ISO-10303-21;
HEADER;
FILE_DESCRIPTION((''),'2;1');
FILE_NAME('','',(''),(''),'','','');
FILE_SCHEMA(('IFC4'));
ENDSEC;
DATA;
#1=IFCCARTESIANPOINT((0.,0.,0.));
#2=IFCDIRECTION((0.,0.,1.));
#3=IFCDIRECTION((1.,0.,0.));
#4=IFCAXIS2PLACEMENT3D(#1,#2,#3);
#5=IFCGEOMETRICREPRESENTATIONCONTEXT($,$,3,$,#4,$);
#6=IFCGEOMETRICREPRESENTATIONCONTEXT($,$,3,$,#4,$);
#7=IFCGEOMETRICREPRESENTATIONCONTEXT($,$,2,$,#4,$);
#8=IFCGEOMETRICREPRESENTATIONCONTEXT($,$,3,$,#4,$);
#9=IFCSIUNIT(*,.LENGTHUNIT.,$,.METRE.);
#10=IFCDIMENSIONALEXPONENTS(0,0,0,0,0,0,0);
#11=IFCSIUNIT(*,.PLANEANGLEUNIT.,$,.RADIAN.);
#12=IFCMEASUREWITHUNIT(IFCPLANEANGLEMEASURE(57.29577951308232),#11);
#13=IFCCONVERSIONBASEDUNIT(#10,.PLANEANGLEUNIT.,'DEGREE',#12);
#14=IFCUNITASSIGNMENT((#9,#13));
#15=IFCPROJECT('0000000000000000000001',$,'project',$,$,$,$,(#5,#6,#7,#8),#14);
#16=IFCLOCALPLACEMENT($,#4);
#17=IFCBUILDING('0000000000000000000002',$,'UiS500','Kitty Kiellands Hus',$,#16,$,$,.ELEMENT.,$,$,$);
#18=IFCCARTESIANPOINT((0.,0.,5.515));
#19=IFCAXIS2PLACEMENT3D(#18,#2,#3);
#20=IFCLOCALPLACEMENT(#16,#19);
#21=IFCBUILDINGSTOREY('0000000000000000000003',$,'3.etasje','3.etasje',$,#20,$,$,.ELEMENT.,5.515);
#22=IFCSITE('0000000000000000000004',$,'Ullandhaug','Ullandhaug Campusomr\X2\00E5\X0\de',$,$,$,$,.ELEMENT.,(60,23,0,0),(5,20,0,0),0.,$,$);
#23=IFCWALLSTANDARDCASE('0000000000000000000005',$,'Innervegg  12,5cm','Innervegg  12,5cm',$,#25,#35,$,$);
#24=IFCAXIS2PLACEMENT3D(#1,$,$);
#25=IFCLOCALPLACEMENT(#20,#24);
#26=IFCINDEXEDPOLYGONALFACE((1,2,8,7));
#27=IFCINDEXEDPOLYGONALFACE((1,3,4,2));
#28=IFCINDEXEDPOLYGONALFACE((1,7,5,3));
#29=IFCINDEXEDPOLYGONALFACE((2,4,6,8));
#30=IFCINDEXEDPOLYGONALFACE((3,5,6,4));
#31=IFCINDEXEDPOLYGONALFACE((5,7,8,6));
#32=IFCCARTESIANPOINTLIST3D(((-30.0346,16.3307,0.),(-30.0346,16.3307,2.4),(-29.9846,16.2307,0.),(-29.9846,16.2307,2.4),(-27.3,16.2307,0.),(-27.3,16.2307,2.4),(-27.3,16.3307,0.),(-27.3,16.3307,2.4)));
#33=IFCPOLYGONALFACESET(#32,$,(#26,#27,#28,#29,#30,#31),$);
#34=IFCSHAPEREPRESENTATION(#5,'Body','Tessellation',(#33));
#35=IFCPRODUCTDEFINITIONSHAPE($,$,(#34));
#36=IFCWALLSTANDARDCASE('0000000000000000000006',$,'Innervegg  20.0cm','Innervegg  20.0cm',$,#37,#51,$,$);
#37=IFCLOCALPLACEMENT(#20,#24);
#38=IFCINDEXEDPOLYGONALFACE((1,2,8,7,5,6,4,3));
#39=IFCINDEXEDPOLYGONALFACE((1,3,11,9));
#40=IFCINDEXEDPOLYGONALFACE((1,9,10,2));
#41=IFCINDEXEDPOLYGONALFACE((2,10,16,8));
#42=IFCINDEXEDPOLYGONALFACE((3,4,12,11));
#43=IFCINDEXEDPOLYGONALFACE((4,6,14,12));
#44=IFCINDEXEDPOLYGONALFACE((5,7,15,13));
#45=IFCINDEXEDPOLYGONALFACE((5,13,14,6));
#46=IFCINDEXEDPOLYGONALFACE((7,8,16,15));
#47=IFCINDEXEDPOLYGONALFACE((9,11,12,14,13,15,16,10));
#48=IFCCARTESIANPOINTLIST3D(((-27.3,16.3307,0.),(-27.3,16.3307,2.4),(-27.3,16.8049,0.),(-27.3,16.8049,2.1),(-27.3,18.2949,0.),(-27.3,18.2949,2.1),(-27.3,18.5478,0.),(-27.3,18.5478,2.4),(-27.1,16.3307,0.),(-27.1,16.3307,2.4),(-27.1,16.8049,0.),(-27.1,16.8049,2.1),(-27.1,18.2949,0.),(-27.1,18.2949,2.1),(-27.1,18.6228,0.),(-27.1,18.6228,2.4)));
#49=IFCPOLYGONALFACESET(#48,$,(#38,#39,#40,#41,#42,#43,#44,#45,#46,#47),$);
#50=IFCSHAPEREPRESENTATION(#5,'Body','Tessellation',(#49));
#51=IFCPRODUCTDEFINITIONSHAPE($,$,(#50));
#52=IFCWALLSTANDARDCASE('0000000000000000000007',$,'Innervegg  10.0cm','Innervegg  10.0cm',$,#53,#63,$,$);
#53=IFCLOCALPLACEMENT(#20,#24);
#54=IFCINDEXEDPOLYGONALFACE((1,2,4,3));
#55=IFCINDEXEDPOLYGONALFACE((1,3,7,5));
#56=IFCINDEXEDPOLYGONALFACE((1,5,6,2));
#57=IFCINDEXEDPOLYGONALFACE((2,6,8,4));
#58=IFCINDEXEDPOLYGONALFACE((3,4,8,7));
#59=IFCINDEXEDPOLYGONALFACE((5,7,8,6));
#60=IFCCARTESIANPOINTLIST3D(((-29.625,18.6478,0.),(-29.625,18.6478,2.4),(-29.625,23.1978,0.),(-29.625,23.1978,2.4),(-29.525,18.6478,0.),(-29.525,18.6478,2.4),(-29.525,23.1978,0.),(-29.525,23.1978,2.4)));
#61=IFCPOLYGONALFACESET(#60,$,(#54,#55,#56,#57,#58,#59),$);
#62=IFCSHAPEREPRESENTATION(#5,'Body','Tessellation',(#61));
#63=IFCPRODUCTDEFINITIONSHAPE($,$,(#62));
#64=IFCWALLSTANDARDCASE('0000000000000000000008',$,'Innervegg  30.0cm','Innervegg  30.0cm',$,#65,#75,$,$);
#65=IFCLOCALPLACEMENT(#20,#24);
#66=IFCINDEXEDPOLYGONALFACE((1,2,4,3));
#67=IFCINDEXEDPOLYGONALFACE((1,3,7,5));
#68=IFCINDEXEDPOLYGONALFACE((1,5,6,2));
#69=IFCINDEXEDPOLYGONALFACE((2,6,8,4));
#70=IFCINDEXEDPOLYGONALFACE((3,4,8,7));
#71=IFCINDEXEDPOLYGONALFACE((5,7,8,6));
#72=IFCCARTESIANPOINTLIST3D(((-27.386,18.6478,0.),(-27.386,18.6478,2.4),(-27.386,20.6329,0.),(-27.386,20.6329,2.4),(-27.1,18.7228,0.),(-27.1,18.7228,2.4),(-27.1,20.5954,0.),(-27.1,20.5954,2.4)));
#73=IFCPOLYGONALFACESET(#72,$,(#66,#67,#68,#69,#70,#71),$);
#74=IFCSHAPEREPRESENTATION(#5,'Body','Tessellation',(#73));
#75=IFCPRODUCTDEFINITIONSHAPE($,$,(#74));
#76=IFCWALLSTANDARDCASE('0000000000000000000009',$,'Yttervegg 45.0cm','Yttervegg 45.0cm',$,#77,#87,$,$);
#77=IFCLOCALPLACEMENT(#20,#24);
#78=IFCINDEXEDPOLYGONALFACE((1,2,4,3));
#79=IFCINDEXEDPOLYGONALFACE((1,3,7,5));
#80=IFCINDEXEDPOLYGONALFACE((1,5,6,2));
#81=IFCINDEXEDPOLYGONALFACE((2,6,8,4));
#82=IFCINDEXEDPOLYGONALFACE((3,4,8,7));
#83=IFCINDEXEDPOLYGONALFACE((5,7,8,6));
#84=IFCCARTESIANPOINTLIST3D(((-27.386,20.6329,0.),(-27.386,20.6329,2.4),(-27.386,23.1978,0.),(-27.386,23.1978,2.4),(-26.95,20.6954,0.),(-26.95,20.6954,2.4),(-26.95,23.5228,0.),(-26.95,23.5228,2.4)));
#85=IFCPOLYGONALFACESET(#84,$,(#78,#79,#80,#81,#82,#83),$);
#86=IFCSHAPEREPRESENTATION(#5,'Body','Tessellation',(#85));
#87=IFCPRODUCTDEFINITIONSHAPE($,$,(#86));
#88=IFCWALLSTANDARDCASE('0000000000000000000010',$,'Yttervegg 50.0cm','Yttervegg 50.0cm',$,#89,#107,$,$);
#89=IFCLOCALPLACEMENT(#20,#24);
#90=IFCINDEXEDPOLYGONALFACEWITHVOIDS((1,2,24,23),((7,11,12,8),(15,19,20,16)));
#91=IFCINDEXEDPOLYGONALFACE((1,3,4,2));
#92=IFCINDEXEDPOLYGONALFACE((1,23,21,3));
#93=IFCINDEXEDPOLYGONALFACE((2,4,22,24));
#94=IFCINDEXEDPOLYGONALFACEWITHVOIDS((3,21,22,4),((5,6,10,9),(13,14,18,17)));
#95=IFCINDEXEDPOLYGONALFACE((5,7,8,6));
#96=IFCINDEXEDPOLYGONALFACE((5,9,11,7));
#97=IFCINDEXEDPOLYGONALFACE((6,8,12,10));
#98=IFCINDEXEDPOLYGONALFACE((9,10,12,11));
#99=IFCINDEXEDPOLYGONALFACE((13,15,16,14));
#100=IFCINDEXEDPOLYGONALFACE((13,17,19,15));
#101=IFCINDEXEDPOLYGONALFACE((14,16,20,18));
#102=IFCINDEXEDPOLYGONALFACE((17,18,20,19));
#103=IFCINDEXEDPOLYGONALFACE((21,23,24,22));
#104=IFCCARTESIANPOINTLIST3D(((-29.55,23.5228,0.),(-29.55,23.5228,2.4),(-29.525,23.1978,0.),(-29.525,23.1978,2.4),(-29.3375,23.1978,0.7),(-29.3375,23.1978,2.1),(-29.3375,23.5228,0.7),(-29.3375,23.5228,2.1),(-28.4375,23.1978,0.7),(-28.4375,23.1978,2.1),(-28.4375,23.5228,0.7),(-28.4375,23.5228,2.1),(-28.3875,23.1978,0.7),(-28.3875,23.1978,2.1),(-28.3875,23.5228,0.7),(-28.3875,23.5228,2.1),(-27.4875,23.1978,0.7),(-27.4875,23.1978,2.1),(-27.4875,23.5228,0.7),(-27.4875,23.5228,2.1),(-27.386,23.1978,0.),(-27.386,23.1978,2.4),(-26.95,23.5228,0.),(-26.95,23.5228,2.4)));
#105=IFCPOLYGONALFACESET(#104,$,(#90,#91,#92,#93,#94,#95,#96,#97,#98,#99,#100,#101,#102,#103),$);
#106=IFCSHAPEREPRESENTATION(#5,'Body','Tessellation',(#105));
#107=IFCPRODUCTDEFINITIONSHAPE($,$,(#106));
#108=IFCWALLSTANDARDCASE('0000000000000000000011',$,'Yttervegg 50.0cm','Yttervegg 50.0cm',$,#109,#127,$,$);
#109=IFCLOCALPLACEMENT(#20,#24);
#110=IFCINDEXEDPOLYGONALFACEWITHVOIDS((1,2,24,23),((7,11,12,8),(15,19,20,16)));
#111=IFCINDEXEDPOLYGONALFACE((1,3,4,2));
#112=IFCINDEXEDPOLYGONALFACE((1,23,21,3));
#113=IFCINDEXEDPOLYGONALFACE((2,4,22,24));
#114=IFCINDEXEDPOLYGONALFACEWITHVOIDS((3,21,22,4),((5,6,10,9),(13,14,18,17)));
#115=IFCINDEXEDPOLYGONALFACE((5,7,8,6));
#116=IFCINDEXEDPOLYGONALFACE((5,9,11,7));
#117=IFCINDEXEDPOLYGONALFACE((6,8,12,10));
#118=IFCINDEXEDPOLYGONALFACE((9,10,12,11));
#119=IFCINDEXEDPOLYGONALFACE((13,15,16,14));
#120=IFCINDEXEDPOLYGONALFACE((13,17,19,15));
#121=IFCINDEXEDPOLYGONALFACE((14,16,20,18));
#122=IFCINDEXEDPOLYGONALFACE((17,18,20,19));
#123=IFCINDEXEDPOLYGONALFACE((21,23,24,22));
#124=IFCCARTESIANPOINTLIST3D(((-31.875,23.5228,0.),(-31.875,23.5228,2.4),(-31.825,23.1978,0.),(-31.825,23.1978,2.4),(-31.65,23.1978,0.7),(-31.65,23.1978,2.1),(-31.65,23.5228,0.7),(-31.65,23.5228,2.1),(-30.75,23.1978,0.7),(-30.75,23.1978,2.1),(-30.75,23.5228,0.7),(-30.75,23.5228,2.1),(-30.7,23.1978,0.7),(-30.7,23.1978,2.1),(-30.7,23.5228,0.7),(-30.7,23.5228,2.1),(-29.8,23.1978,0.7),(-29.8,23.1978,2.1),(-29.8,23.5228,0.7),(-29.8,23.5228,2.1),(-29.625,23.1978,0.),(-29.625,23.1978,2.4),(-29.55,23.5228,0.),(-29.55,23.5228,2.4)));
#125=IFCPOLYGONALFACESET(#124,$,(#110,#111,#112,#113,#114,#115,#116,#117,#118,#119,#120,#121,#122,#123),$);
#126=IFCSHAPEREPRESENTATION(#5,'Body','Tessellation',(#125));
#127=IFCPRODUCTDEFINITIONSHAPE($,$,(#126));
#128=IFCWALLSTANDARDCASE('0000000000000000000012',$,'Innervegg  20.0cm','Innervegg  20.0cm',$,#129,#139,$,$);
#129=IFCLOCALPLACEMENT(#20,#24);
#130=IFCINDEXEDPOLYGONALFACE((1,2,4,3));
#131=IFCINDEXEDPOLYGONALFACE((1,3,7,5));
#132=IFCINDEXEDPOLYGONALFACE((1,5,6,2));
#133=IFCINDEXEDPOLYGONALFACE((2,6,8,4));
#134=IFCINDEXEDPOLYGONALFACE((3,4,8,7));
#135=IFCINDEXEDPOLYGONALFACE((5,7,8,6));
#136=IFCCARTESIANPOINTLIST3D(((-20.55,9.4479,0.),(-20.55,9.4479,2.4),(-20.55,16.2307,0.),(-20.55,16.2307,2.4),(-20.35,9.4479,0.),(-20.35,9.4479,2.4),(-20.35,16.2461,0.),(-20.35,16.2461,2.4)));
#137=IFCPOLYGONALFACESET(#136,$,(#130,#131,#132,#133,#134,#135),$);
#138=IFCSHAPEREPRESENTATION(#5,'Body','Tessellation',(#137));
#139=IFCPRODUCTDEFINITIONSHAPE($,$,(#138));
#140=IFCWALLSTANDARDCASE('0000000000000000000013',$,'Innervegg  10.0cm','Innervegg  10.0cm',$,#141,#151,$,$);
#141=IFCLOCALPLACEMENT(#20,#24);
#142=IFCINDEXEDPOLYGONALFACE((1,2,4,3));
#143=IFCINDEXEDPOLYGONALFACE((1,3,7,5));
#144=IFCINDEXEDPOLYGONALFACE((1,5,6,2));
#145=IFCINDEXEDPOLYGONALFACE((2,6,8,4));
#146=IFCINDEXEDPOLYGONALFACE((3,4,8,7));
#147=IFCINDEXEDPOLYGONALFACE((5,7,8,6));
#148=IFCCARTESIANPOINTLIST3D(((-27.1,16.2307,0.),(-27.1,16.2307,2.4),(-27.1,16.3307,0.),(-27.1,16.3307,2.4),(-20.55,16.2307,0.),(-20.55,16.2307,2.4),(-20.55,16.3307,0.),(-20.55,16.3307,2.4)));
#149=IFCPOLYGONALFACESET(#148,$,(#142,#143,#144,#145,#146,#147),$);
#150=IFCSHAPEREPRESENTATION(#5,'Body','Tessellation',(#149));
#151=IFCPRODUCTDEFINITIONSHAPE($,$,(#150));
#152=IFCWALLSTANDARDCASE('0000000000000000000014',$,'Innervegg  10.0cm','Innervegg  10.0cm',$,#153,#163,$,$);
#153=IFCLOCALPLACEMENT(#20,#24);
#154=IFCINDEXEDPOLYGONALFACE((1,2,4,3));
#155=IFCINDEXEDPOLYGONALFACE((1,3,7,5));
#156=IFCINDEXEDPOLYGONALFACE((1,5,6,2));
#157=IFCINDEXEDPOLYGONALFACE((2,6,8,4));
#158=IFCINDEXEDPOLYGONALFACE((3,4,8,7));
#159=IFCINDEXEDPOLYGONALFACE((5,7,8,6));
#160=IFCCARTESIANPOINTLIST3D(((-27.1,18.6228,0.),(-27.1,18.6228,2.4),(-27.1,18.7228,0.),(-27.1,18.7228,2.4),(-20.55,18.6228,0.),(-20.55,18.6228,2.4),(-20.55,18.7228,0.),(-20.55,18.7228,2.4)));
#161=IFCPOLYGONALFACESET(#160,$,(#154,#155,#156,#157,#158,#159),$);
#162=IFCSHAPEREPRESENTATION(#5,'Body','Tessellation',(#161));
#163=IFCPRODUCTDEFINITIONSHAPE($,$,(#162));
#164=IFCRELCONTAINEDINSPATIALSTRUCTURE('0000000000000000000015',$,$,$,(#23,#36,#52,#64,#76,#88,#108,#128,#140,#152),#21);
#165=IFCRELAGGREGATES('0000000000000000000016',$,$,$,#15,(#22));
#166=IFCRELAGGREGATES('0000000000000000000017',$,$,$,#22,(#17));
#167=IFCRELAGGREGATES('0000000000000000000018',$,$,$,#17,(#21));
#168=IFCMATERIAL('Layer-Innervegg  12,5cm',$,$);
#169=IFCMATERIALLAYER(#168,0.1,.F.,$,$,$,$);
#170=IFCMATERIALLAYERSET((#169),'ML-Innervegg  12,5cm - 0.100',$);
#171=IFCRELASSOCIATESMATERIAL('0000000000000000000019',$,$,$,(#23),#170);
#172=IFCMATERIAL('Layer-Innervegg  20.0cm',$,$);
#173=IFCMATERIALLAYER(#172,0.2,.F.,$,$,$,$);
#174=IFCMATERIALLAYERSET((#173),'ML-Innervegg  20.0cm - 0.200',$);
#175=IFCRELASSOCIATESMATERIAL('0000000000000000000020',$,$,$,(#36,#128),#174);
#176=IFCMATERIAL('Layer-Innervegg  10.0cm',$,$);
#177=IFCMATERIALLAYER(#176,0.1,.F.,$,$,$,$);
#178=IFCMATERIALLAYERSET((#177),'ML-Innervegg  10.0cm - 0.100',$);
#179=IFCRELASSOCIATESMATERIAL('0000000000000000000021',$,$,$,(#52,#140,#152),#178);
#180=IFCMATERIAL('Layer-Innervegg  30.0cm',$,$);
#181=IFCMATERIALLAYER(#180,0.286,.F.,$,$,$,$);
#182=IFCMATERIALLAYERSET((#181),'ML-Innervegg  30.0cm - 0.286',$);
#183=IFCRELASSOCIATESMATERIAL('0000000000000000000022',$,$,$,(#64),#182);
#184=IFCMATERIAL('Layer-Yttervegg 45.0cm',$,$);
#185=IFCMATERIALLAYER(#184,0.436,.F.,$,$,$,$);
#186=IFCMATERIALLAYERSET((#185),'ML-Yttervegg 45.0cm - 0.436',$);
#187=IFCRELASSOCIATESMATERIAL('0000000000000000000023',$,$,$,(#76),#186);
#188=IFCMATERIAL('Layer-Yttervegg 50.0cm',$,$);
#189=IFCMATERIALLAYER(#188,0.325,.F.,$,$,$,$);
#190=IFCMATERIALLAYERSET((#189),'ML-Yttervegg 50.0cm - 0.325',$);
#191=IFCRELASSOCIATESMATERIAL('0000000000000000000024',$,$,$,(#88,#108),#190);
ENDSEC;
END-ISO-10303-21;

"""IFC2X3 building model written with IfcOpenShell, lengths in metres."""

from ifc_helpers import new_model, entity, si_unit, converted_unit, frame, origin_with_axes, place, context, project, spatial, polyline, outline, extrude, material, layer, layer_set, layer_usage, element, save


model = new_model("IFC2X3")

# Units and contexts
context_of_model_1 = context(None, 3, world=origin_with_axes())
context_of_model_2 = context(None, 3, world=origin_with_axes())
context_of_model_3 = context(None, 2, world=origin_with_axes())
context_of_model_4 = context(None, 3, world=origin_with_axes())
ifc_project = project(units=[si_unit("LENGTHUNIT", "METRE"), converted_unit("PLANEANGLEUNIT", "DEGREE", entity("IfcPlaneAngleMeasure", 57.29577951308232), si_unit("PLANEANGLEUNIT", "RADIAN"), dimensions=[0, 0, 0, 0, 0, 0, 0])], contexts=[context_of_model_1, context_of_model_2, context_of_model_3, context_of_model_4])

# Site, building, storey
site = spatial("IfcSite", under=ifc_project, Name="Ullandhaug", Description="Ullandhaug Campusområde", CompositionType="ELEMENT", RefLatitude=(60, 23, 0, 0), RefLongitude=(5, 20, 0, 0), RefElevation=0.0)
building_placement = place(None, origin_with_axes())
building = spatial("IfcBuilding", under=site, at=building_placement, Name="UiS500", Description="Kitty Kiellands Hus", CompositionType="ELEMENT")
storey_placement = place(building_placement, frame((0.0, 0.0, 5.515), z_axis=(0.0, 0.0, 1.0), x_axis=(1.0, 0.0, 0.0)))
storey = spatial("IfcBuildingStorey", under=building, at=storey_placement, Name="3.etasje", Description="3.etasje", CompositionType="ELEMENT", Elevation=5.515)

# Shared definitions
ifc_material_1 = material(Name="Layer-Innervegg  20.0cm")
ifc_layer_1 = layer(ifc_material_1, 0.2, ventilated=False)
ifc_layer_set_1 = layer_set([ifc_layer_1], Name="ML-Innervegg  20.0cm - 0.200")
ifc_layer_usage_1 = layer_usage(ifc_layer_set_1, "AXIS2", "POSITIVE", 0.0)
ifc_material_2 = material(Name="Layer-Innervegg  10.0cm")
ifc_layer_2 = layer(ifc_material_2, 0.1, ventilated=False)
ifc_layer_set_2 = layer_set([ifc_layer_2], Name="ML-Innervegg  10.0cm - 0.100")
ifc_layer_usage_2 = layer_usage(ifc_layer_set_2, "AXIS2", "POSITIVE", 0.0)

# Wall
ifc_material_3 = material(Name="Layer-Innervegg  12,5cm")
ifc_layer_3 = layer(ifc_material_3, 0.1, ventilated=False)
ifc_layer_set_3 = layer_set([ifc_layer_3], Name="ML-Innervegg  12,5cm - 0.100")
ifc_layer_usage_3 = layer_usage(ifc_layer_set_3, "AXIS2", "POSITIVE", 0.0)
wall_1_placement = place(storey_placement, frame((-29.9846, 16.2307, 0.0), z_axis=(0.0, 0.0, 1.0), x_axis=(1.0, 0.0, 0.0)))
element("IfcWallStandardCase", 1, at=wall_1_placement, inside=storey, material=ifc_layer_usage_3, Name="Innervegg  12,5cm", Description="Innervegg  12,5cm", context=context_of_model_1, shape_type="SweptSolid", body=[
    extrude(outline(polyline([(0.0, 0.0), (2.6846, 0.0), (2.6846, 0.1), (-0.05, 0.1), (0.0, 0.0)])), origin_with_axes(), (0.0, 0.0, 1.0), 2.4),
])

# Wall, opening
wall_2_placement = place(storey_placement, frame((-27.1, 16.3307, 0.0), z_axis=(0.0, 0.0, 1.0), x_axis=(0.0, 1.0, 0.0)))
wall_2 = element("IfcWallStandardCase", 2, at=wall_2_placement, inside=storey, material=ifc_layer_usage_1, Name="Innervegg  20.0cm", Description="Innervegg  20.0cm", context=context_of_model_1, shape_type="SweptSolid", body=[
    extrude(outline(polyline([(0.0, 0.0), (2.292, 0.0), (2.217, 0.2), (0.0, 0.2), (0.0, 0.0)])), frame((0.0, 0.0, 0.0), z_axis=(0.0, 0.0, 1.0), x_axis=(1.0, 0.0, 0.0)), (0.0, 0.0, 1.0), 2.4),
])
opening_1_placement = place(wall_2_placement, frame((0.4742, 0.2, 0.0), z_axis=(0.0, 0.0, 1.0), x_axis=(1.0, 0.0, 0.0)))
element("IfcOpeningElement", 3, at=opening_1_placement, cuts=wall_2, context=context_of_model_1, shape_type="SweptSolid", body=[
    extrude(outline(polyline([(0.0, 0.0), (2.1, 0.0), (2.1, 1.49), (0.0, 1.49), (0.0, 0.0)])), frame((0.0, 0.0, 0.0), z_axis=(0.0, 1.0, 0.0), x_axis=(0.0, 0.0, 1.0)), (0.0, 0.0, -1.0), 0.2),
])

# Walls
wall_3_placement = place(storey_placement, frame((-29.625, 23.1978, 0.0), z_axis=(0.0, 0.0, 1.0), x_axis=(0.0, -1.0, 0.0)))
element("IfcWallStandardCase", 4, at=wall_3_placement, inside=storey, material=ifc_layer_usage_2, Name="Innervegg  10.0cm", Description="Innervegg  10.0cm", context=context_of_model_1, shape_type="SweptSolid", body=[
    extrude(outline(polyline([(0.0, 0.0), (4.55, 0.0), (4.55, 0.1), (0.0, 0.1), (0.0, 0.0)])), frame((0.0, 0.0, 0.0), z_axis=(0.0, 0.0, 1.0), x_axis=(1.0, 0.0, 0.0)), (0.0, 0.0, 1.0), 2.4),
])
ifc_material_4 = material(Name="Layer-Innervegg  30.0cm")
ifc_layer_4 = layer(ifc_material_4, 0.286, ventilated=False)
ifc_layer_set_4 = layer_set([ifc_layer_4], Name="ML-Innervegg  30.0cm - 0.286")
ifc_layer_usage_4 = layer_usage(ifc_layer_set_4, "AXIS2", "POSITIVE", 0.0)
wall_4_placement = place(storey_placement, frame((-27.1, 18.7228, 0.0), z_axis=(0.0, 0.0, 1.0), x_axis=(0.0, 1.0, 0.0)))
element("IfcWallStandardCase", 5, at=wall_4_placement, inside=storey, material=ifc_layer_usage_4, Name="Innervegg  30.0cm", Description="Innervegg  30.0cm", context=context_of_model_1, shape_type="SweptSolid", body=[
    extrude(outline(polyline([(0.0, 0.0), (1.8727, 0.0), (1.9102, 0.286), (-0.075, 0.286), (0.0, 0.0)])), frame((0.0, 0.0, 0.0), z_axis=(0.0, 0.0, 1.0), x_axis=(1.0, 0.0, 0.0)), (0.0, 0.0, 1.0), 2.4),
])
ifc_material_5 = material(Name="Layer-Yttervegg 45.0cm")
ifc_layer_5 = layer(ifc_material_5, 0.436, ventilated=False)
ifc_layer_set_5 = layer_set([ifc_layer_5], Name="ML-Yttervegg 45.0cm - 0.436")
ifc_layer_usage_5 = layer_usage(ifc_layer_set_5, "AXIS2", "POSITIVE", 0.0)
wall_5_placement = place(storey_placement, frame((-26.95, 20.6954, 0.0), z_axis=(0.0, 0.0, 1.0), x_axis=(0.0, 1.0, 0.0)))
element("IfcWallStandardCase", 6, at=wall_5_placement, inside=storey, material=ifc_layer_usage_5, Name="Yttervegg 45.0cm", Description="Yttervegg 45.0cm", context=context_of_model_1, shape_type="SweptSolid", body=[
    extrude(outline(polyline([(0.0, 0.0), (2.8273, 0.0), (2.5023, 0.436), (-0.0625, 0.436), (0.0, 0.0)])), frame((0.0, 0.0, 0.0), z_axis=(0.0, 0.0, 1.0), x_axis=(1.0, 0.0, 0.0)), (0.0, 0.0, 1.0), 2.4),
])

# Walls, openings
ifc_material_6 = material(Name="Layer-Yttervegg 50.0cm")
ifc_layer_6 = layer(ifc_material_6, 0.325, ventilated=False)
ifc_layer_set_6 = layer_set([ifc_layer_6], Name="ML-Yttervegg 50.0cm - 0.325")
ifc_layer_usage_6 = layer_usage(ifc_layer_set_6, "AXIS2", "POSITIVE", 0.0)
wall_6_placement = place(storey_placement, frame((-26.95, 23.5228, 0.0), z_axis=(0.0, 0.0, 1.0), x_axis=(-1.0, 0.0, 0.0)))
wall_6 = element("IfcWallStandardCase", 7, at=wall_6_placement, inside=storey, material=ifc_layer_usage_6, Name="Yttervegg 50.0cm", Description="Yttervegg 50.0cm", context=context_of_model_1, shape_type="SweptSolid", body=[
    extrude(outline(polyline([(0.0, 0.0), (2.6, 0.0), (2.575, 0.325), (0.436, 0.325), (0.0, 0.0)])), frame((0.0, 0.0, 0.0), z_axis=(0.0, 0.0, 1.0), x_axis=(1.0, 0.0, 0.0)), (0.0, 0.0, 1.0), 2.4),
])
opening_2_placement = place(wall_6_placement, frame((1.4875, 0.325, 0.7), z_axis=(0.0, 0.0, 1.0), x_axis=(1.0, 0.0, 0.0)))
element("IfcOpeningElement", 8, at=opening_2_placement, cuts=wall_6, context=context_of_model_1, shape_type="SweptSolid", body=[
    extrude(outline(polyline([(0.0, 0.0), (1.4, 0.0), (1.4, 0.9), (0.0, 0.9), (0.0, 0.0)])), frame((0.0, 0.0, 0.0), z_axis=(0.0, 1.0, 0.0), x_axis=(0.0, 0.0, 1.0)), (0.0, 0.0, -1.0), 0.325),
])
opening_3_placement = place(wall_6_placement, frame((0.5375, 0.325, 0.7), z_axis=(0.0, 0.0, 1.0), x_axis=(1.0, 0.0, 0.0)))
element("IfcOpeningElement", 9, at=opening_3_placement, cuts=wall_6, context=context_of_model_1, shape_type="SweptSolid", body=[
    extrude(outline(polyline([(0.0, 0.0), (1.4, 0.0), (1.4, 0.9), (0.0, 0.9), (0.0, 0.0)])), frame((0.0, 0.0, 0.0), z_axis=(0.0, 1.0, 0.0), x_axis=(0.0, 0.0, 1.0)), (0.0, 0.0, -1.0), 0.325),
])
wall_7_placement = place(storey_placement, frame((-29.55, 23.5228, 0.0), z_axis=(0.0, 0.0, 1.0), x_axis=(-1.0, 0.0, 0.0)))
wall_7 = element("IfcWallStandardCase", 10, at=wall_7_placement, inside=storey, material=ifc_layer_usage_6, Name="Yttervegg 50.0cm", Description="Yttervegg 50.0cm", context=context_of_model_1, shape_type="SweptSolid", body=[
    extrude(outline(polyline([(0.0, 0.0), (2.325, 0.0), (2.275, 0.325), (0.075, 0.325), (0.0, 0.0)])), frame((0.0, 0.0, 0.0), z_axis=(0.0, 0.0, 1.0), x_axis=(1.0, 0.0, 0.0)), (0.0, 0.0, 1.0), 2.4),
])
opening_4_placement = place(wall_7_placement, frame((0.25, 0.325, 0.7), z_axis=(0.0, 0.0, 1.0), x_axis=(1.0, 0.0, 0.0)))
element("IfcOpeningElement", 11, at=opening_4_placement, cuts=wall_7, context=context_of_model_1, shape_type="SweptSolid", body=[
    extrude(outline(polyline([(0.0, 0.0), (1.4, 0.0), (1.4, 0.9), (0.0, 0.9), (0.0, 0.0)])), frame((0.0, 0.0, 0.0), z_axis=(0.0, 1.0, 0.0), x_axis=(0.0, 0.0, 1.0)), (0.0, 0.0, -1.0), 0.325),
])
opening_5_placement = place(wall_7_placement, frame((1.2, 0.325, 0.7), z_axis=(0.0, 0.0, 1.0), x_axis=(1.0, 0.0, 0.0)))
element("IfcOpeningElement", 12, at=opening_5_placement, cuts=wall_7, context=context_of_model_1, shape_type="SweptSolid", body=[
    extrude(outline(polyline([(0.0, 0.0), (1.4, 0.0), (1.4, 0.9), (0.0, 0.9), (0.0, 0.0)])), frame((0.0, 0.0, 0.0), z_axis=(0.0, 1.0, 0.0), x_axis=(0.0, 0.0, 1.0)), (0.0, 0.0, -1.0), 0.325),
])

# Walls
wall_8_placement = place(storey_placement, frame((-20.55, 16.2307, 0.0), z_axis=(0.0, 0.0, 1.0), x_axis=(0.0, -1.0, 0.0)))
element("IfcWallStandardCase", 13, at=wall_8_placement, inside=storey, material=ifc_layer_usage_1, Name="Innervegg  20.0cm", Description="Innervegg  20.0cm", context=context_of_model_1, shape_type="SweptSolid", body=[
    extrude(outline(polyline([(0.0, 0.0), (6.7828, 0.0), (6.7828, 0.2), (-0.0153, 0.2), (0.0, 0.0)])), frame((0.0, 0.0, 0.0), z_axis=(0.0, 0.0, 1.0), x_axis=(1.0, 0.0, 0.0)), (0.0, 0.0, 1.0), 2.4),
])
wall_9_placement = place(storey_placement, frame((-27.1, 16.2307, 0.0), z_axis=(0.0, 0.0, 1.0), x_axis=(1.0, 0.0, 0.0)))
element("IfcWallStandardCase", 14, at=wall_9_placement, inside=storey, material=ifc_layer_usage_2, Name="Innervegg  10.0cm", Description="Innervegg  10.0cm", context=context_of_model_1, shape_type="SweptSolid", body=[
    extrude(outline(polyline([(0.0, 0.0), (6.55, 0.0), (6.55, 0.1), (0.0, 0.1), (0.0, 0.0)])), frame((0.0, 0.0, 0.0), z_axis=(0.0, 0.0, 1.0), x_axis=(1.0, 0.0, 0.0)), (0.0, 0.0, 1.0), 2.4),
])
wall_10_placement = place(storey_placement, frame((-20.55, 18.7228, 0.0), z_axis=(0.0, 0.0, 1.0), x_axis=(-1.0, 0.0, 0.0)))
element("IfcWallStandardCase", 15, at=wall_10_placement, inside=storey, material=ifc_layer_usage_2, Name="Innervegg  10.0cm", Description="Innervegg  10.0cm", context=context_of_model_1, shape_type="SweptSolid", body=[
    extrude(outline(polyline([(0.0, 0.0), (6.55, 0.0), (6.55, 0.1), (0.0, 0.1), (0.0, 0.0)])), frame((0.0, 0.0, 0.0), z_axis=(0.0, 0.0, 1.0), x_axis=(1.0, 0.0, 0.0)), (0.0, 0.0, 1.0), 2.4),
])

save(model, "model.ifc")
